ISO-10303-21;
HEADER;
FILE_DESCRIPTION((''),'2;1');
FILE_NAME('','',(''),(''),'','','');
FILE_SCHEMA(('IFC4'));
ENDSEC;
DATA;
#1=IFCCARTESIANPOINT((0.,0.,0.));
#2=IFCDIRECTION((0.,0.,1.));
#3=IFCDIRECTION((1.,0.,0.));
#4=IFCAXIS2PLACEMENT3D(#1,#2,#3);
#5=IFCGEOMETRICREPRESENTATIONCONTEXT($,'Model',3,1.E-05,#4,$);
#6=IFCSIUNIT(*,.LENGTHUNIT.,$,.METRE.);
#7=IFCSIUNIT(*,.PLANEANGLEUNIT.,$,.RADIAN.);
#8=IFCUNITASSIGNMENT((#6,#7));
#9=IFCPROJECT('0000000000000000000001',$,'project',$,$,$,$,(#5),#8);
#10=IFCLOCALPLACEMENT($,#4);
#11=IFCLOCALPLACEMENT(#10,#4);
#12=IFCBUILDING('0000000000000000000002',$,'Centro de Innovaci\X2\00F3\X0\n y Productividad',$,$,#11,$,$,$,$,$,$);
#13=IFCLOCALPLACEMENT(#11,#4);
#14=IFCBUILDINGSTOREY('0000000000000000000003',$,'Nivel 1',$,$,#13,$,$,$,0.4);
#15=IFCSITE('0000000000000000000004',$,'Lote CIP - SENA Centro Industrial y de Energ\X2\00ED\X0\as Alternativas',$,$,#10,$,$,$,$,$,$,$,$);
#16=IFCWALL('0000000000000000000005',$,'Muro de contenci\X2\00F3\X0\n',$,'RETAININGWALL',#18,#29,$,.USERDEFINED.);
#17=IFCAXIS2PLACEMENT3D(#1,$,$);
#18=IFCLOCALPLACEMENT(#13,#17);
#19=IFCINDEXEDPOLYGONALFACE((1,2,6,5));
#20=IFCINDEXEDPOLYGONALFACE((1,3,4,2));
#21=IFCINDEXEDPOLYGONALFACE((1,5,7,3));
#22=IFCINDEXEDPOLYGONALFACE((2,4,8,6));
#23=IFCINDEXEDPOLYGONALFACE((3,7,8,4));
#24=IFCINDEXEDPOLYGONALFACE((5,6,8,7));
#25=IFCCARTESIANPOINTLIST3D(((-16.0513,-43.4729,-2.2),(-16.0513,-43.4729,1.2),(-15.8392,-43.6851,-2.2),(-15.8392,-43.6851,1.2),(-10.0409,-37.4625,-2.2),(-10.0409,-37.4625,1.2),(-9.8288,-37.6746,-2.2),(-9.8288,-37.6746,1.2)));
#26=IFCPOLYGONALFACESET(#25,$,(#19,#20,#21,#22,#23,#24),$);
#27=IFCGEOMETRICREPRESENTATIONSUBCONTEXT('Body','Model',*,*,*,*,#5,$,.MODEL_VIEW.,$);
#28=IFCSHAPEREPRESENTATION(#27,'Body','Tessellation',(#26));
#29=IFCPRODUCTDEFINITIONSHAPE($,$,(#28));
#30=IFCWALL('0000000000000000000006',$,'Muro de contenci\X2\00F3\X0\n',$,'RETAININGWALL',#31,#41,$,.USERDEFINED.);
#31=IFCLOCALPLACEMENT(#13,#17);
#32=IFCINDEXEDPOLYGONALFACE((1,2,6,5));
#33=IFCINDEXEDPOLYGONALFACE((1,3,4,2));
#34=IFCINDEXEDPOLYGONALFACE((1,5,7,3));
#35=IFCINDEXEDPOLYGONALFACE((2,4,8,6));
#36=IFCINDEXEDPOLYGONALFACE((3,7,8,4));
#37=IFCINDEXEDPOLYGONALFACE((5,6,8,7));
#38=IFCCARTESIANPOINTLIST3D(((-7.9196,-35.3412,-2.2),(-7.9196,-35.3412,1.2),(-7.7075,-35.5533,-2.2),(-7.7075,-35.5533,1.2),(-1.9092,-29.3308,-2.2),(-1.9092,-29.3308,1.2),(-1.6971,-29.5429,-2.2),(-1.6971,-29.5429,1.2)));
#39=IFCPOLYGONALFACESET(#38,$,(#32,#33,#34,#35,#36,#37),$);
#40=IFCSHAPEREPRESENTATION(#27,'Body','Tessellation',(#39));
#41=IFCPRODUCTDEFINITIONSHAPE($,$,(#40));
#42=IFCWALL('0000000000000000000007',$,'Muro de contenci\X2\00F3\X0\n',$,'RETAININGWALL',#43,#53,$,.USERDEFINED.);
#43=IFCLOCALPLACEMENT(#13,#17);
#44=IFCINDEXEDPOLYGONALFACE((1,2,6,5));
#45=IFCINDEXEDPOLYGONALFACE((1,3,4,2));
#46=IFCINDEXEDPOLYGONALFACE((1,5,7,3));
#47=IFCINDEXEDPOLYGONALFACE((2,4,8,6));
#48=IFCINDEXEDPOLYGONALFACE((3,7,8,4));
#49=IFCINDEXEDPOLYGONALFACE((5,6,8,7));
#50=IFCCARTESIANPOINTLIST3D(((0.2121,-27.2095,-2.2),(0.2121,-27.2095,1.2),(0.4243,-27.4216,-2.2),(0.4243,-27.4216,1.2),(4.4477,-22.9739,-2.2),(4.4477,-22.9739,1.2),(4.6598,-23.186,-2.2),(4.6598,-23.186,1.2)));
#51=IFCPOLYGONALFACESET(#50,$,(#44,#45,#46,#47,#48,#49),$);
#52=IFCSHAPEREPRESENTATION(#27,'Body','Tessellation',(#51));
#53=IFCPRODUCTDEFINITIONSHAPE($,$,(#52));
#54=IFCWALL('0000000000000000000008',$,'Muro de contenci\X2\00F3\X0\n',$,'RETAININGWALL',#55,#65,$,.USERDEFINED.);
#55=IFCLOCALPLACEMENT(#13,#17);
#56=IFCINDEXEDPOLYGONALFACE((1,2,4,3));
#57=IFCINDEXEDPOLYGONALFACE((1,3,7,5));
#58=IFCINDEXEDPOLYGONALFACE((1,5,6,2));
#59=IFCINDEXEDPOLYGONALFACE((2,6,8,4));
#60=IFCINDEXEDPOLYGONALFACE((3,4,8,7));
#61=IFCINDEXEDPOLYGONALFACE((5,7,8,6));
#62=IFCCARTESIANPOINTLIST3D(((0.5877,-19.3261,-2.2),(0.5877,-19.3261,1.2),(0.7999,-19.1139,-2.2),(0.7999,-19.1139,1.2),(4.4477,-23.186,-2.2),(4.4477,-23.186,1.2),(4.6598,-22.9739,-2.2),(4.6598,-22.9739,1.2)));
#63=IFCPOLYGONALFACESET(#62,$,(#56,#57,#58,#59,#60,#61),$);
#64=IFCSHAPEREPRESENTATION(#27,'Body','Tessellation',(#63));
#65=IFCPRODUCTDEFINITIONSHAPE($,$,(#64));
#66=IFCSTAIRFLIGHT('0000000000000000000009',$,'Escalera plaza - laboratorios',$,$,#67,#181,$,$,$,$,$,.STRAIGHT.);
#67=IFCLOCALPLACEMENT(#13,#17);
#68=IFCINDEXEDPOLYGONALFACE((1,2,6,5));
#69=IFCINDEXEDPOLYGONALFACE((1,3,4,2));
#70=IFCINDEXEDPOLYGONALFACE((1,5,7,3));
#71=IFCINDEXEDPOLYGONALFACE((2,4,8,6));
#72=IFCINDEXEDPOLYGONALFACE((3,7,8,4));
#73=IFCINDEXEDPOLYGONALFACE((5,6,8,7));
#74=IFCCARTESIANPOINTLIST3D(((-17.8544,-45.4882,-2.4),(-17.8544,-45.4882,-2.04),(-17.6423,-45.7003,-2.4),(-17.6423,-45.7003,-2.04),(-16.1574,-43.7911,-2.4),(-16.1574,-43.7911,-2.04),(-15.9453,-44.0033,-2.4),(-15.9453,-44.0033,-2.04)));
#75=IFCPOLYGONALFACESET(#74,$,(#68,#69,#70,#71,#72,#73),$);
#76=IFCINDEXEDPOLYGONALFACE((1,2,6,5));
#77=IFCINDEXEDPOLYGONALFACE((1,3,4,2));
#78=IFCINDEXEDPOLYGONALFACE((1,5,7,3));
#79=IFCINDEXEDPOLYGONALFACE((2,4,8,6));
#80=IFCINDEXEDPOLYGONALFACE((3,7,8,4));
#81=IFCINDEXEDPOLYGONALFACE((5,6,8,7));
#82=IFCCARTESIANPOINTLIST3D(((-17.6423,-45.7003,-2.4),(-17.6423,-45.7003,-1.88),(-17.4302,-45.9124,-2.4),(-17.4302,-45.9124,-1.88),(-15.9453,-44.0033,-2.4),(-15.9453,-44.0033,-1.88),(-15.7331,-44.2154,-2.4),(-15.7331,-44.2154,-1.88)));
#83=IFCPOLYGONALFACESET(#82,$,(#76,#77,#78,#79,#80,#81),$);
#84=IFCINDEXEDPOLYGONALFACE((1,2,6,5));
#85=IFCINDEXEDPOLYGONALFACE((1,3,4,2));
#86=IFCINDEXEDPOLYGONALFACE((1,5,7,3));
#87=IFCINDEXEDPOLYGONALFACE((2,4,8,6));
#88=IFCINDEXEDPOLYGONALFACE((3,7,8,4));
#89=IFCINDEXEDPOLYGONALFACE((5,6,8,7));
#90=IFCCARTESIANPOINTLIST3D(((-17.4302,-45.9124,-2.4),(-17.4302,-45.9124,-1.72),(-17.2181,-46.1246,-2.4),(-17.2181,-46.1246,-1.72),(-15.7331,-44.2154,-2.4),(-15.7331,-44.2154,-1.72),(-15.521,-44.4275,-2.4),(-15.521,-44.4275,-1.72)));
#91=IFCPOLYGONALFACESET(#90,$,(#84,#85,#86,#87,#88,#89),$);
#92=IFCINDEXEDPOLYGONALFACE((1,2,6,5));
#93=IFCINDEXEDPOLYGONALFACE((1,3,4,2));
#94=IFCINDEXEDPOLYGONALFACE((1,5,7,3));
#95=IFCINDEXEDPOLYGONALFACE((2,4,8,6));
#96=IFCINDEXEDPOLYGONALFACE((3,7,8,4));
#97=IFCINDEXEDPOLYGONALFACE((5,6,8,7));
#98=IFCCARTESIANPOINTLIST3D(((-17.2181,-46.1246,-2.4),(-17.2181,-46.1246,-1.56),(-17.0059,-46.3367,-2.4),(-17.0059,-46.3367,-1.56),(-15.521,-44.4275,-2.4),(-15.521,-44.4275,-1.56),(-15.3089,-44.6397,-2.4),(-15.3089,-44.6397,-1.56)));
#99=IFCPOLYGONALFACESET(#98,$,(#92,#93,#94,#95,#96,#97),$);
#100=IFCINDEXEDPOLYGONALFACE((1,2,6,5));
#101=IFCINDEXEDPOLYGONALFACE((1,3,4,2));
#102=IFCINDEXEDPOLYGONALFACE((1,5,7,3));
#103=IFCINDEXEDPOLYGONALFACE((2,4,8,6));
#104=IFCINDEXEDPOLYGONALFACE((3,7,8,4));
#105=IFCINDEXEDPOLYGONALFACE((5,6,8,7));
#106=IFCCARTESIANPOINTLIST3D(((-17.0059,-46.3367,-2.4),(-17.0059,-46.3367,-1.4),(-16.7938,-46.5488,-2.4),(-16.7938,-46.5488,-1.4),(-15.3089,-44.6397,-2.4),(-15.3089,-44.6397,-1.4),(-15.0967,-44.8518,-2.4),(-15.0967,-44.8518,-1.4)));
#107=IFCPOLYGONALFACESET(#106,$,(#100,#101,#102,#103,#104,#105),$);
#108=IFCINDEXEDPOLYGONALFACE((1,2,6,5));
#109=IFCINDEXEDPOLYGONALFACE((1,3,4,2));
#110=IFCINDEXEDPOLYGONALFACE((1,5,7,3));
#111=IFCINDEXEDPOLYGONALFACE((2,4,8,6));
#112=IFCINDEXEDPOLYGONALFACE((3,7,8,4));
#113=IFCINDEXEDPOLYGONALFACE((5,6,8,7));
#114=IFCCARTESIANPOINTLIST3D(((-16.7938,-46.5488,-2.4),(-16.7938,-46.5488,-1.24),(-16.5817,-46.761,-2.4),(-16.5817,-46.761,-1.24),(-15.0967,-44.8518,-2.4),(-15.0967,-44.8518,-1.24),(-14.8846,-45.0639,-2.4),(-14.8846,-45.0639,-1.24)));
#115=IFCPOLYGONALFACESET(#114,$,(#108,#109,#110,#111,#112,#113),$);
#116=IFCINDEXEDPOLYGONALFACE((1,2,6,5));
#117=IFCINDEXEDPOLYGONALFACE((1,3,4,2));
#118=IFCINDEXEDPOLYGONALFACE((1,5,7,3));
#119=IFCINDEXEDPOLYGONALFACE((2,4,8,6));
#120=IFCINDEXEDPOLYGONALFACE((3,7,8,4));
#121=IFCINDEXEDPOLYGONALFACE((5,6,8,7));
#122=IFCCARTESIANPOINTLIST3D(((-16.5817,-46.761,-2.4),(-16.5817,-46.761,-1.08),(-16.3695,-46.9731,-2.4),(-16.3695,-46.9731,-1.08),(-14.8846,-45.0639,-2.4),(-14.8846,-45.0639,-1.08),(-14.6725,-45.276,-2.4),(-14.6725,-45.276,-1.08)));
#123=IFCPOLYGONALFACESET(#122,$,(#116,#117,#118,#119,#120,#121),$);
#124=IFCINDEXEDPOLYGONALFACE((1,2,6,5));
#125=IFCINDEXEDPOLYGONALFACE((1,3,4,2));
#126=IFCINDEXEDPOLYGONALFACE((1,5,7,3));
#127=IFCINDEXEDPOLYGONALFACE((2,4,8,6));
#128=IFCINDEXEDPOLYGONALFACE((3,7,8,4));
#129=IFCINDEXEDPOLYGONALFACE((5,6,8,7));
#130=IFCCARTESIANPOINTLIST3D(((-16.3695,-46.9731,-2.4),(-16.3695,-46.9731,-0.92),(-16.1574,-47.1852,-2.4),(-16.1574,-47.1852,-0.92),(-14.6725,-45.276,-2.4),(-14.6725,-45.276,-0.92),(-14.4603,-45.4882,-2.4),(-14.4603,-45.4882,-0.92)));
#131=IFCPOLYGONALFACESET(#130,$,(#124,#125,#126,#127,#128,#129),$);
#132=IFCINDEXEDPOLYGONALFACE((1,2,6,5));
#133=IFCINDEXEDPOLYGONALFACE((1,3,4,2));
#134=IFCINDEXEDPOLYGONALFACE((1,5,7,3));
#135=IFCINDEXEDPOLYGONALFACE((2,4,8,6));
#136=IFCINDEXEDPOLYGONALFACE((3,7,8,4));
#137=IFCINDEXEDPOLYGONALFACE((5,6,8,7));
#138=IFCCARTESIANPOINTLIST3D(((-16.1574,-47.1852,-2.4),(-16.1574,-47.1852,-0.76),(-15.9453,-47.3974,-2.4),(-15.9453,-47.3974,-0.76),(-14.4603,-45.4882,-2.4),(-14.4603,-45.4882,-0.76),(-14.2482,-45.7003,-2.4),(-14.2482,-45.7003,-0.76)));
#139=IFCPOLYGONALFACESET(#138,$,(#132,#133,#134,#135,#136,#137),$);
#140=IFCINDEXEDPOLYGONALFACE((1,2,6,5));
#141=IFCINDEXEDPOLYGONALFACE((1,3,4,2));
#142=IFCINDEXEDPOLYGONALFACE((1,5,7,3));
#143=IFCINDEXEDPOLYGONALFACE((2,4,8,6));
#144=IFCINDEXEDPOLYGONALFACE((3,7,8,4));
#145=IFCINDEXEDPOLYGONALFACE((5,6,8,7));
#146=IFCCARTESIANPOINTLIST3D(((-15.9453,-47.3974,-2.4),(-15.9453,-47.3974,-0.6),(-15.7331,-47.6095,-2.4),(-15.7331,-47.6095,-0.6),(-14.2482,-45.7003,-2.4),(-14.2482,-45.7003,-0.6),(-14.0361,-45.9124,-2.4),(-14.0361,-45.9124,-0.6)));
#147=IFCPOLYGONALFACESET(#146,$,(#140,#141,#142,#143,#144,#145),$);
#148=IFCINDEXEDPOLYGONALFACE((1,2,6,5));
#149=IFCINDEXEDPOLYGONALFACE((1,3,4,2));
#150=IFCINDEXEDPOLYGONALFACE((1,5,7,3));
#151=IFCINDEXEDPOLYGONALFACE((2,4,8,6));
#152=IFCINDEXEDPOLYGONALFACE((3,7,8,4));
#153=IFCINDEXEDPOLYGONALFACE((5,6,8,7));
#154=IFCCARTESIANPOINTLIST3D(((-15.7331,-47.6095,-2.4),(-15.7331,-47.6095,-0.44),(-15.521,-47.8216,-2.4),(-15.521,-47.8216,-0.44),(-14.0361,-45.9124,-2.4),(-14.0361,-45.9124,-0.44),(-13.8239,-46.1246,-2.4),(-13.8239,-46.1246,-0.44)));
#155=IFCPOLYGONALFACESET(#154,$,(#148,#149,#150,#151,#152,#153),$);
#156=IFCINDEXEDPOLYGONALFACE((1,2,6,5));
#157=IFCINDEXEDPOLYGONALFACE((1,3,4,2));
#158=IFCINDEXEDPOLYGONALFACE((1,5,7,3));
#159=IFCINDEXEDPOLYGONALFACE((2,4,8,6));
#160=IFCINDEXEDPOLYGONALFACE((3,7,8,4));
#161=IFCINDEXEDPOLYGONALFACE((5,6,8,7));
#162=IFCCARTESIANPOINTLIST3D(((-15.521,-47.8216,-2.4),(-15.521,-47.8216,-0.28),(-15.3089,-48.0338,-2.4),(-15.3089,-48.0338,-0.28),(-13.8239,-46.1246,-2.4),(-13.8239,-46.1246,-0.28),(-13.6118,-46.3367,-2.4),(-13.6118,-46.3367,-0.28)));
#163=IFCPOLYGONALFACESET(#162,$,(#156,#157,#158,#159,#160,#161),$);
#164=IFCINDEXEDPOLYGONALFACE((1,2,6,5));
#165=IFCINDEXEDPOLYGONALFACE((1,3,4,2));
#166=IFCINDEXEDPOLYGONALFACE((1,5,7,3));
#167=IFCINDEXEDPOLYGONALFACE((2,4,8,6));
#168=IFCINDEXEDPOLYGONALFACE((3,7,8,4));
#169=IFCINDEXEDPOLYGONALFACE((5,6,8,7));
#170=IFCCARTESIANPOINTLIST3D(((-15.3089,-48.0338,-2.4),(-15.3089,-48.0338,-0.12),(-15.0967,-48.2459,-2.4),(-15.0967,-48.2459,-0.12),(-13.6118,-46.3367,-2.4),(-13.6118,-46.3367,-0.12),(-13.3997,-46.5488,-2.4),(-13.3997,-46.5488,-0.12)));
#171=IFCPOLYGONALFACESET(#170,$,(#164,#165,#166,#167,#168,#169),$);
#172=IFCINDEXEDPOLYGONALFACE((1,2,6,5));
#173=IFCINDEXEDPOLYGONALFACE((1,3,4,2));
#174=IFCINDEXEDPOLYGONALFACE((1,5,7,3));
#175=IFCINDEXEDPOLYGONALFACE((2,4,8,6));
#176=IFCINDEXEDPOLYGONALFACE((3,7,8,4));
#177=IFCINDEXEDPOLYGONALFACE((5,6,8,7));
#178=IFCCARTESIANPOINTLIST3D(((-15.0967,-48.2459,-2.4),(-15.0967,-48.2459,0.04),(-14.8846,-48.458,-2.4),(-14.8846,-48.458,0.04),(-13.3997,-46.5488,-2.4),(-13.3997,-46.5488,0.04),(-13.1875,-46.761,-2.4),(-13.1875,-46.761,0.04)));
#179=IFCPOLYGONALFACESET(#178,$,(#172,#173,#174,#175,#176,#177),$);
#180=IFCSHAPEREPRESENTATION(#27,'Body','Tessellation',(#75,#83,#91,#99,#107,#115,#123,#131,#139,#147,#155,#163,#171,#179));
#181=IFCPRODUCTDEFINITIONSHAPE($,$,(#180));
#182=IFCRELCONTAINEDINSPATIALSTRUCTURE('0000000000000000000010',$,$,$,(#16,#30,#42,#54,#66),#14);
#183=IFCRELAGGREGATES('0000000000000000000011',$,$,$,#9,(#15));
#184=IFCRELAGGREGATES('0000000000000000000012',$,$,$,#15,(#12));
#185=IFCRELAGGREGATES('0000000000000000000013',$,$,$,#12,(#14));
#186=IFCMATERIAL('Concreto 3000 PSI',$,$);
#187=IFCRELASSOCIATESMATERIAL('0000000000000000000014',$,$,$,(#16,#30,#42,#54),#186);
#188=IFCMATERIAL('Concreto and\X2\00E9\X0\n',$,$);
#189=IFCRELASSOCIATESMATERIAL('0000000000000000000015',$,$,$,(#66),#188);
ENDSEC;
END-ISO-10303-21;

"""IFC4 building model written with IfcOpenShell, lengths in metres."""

from ifc_helpers import new_model, si_unit, frame, origin_with_axes, place, context, subcontext, project, spatial, polyline, outline, extrude, material, element, save


model = new_model("IFC4")

# Units and contexts
model_context = context("Model", 3, precision=1e-05, world=origin_with_axes())
body_context = subcontext(model_context, "Body", "Model", "MODEL_VIEW")
ifc_project = project(units=[si_unit("LENGTHUNIT", "METRE"), si_unit("PLANEANGLEUNIT", "RADIAN")], contexts=[model_context])

# Site, building, storey
site_placement = place(None, origin_with_axes())
site = spatial("IfcSite", under=ifc_project, at=site_placement, Name="Lote CIP - SENA Centro Industrial y de Energías Alternativas")
building_placement = place(site_placement, origin_with_axes())
building = spatial("IfcBuilding", under=site, at=building_placement, Name="Centro de Innovación y Productividad")
storey_placement = place(building_placement, origin_with_axes())
storey = spatial("IfcBuildingStorey", under=building, at=storey_placement, Name="Nivel 1", Elevation=0.4)

# Shared definitions
ifc_material_1 = material(Name="Concreto andén")

# Walls
ifc_material_2 = material(Name="Concreto 3000 PSI")
wall_1_placement = place(storey_placement, origin_with_axes())
element("IfcWall", 1, at=wall_1_placement, inside=storey, material=ifc_material_2, Name="Muro de contención", ObjectType="RETAININGWALL", PredefinedType="USERDEFINED", context=body_context, shape_type="SweptSolid", body=[
    extrude(outline(polyline([(-10.0409, -37.4625), (-9.8288, -37.6746), (-15.8392, -43.6851), (-16.0513, -43.4729), (-10.0409, -37.4625)])), frame((0.0, 0.0, -2.2)), (0.0, 0.0, 1.0), 3.4),
])
wall_2_placement = place(storey_placement, origin_with_axes())
element("IfcWall", 2, at=wall_2_placement, inside=storey, material=ifc_material_2, Name="Muro de contención", ObjectType="RETAININGWALL", PredefinedType="USERDEFINED", context=body_context, shape_type="SweptSolid", body=[
    extrude(outline(polyline([(-1.9092, -29.3308), (-1.6971, -29.5429), (-7.7075, -35.5533), (-7.9196, -35.3412), (-1.9092, -29.3308)])), frame((0.0, 0.0, -2.2)), (0.0, 0.0, 1.0), 3.4),
])
wall_3_placement = place(storey_placement, origin_with_axes())
element("IfcWall", 3, at=wall_3_placement, inside=storey, material=ifc_material_2, Name="Muro de contención", ObjectType="RETAININGWALL", PredefinedType="USERDEFINED", context=body_context, shape_type="SweptSolid", body=[
    extrude(outline(polyline([(4.4477, -22.9739), (4.6598, -23.186), (0.4243, -27.4216), (0.2121, -27.2095), (4.4477, -22.9739)])), frame((0.0, 0.0, -2.2)), (0.0, 0.0, 1.0), 3.4),
])
wall_4_placement = place(storey_placement, origin_with_axes())
element("IfcWall", 4, at=wall_4_placement, inside=storey, material=ifc_material_2, Name="Muro de contención", ObjectType="RETAININGWALL", PredefinedType="USERDEFINED", context=body_context, shape_type="SweptSolid", body=[
    extrude(outline(polyline([(0.5877, -19.3261), (0.7999, -19.1139), (4.6598, -22.9739), (4.4477, -23.186), (0.5877, -19.3261)])), frame((0.0, 0.0, -2.2)), (0.0, 0.0, 1.0), 3.4),
])

# Stair flight
stair_flight_1_placement = place(storey_placement, origin_with_axes())
element("IfcStairFlight", 5, at=stair_flight_1_placement, inside=storey, material=ifc_material_1, Name="Escalera plaza - laboratorios", PredefinedType="STRAIGHT", context=body_context, shape_type="SweptSolid", body=[
    extrude(outline(polyline([(-17.8544, -45.4882), (-16.1574, -43.7911), (-15.9453, -44.0033), (-17.6423, -45.7003), (-17.8544, -45.4882)])), frame((0.0, 0.0, -2.4)), (0.0, 0.0, 1.0), 0.36),
    extrude(outline(polyline([(-17.6423, -45.7003), (-15.9453, -44.0033), (-15.7331, -44.2154), (-17.4302, -45.9124), (-17.6423, -45.7003)])), frame((0.0, 0.0, -2.4)), (0.0, 0.0, 1.0), 0.52),
    extrude(outline(polyline([(-17.4302, -45.9124), (-15.7331, -44.2154), (-15.521, -44.4275), (-17.2181, -46.1246), (-17.4302, -45.9124)])), frame((0.0, 0.0, -2.4)), (0.0, 0.0, 1.0), 0.68),
    extrude(outline(polyline([(-17.2181, -46.1246), (-15.521, -44.4275), (-15.3089, -44.6397), (-17.0059, -46.3367), (-17.2181, -46.1246)])), frame((0.0, 0.0, -2.4)), (0.0, 0.0, 1.0), 0.84),
    extrude(outline(polyline([(-17.0059, -46.3367), (-15.3089, -44.6397), (-15.0967, -44.8518), (-16.7938, -46.5488), (-17.0059, -46.3367)])), frame((0.0, 0.0, -2.4)), (0.0, 0.0, 1.0), 1.0),
    extrude(outline(polyline([(-16.7938, -46.5488), (-15.0967, -44.8518), (-14.8846, -45.0639), (-16.5817, -46.761), (-16.7938, -46.5488)])), frame((0.0, 0.0, -2.4)), (0.0, 0.0, 1.0), 1.16),
    extrude(outline(polyline([(-16.5817, -46.761), (-14.8846, -45.0639), (-14.6725, -45.276), (-16.3695, -46.9731), (-16.5817, -46.761)])), frame((0.0, 0.0, -2.4)), (0.0, 0.0, 1.0), 1.32),
    extrude(outline(polyline([(-16.3695, -46.9731), (-14.6725, -45.276), (-14.4603, -45.4882), (-16.1574, -47.1852), (-16.3695, -46.9731)])), frame((0.0, 0.0, -2.4)), (0.0, 0.0, 1.0), 1.48),
    extrude(outline(polyline([(-16.1574, -47.1852), (-14.4603, -45.4882), (-14.2482, -45.7003), (-15.9453, -47.3974), (-16.1574, -47.1852)])), frame((0.0, 0.0, -2.4)), (0.0, 0.0, 1.0), 1.64),
    extrude(outline(polyline([(-15.9453, -47.3974), (-14.2482, -45.7003), (-14.0361, -45.9124), (-15.7331, -47.6095), (-15.9453, -47.3974)])), frame((0.0, 0.0, -2.4)), (0.0, 0.0, 1.0), 1.8),
    extrude(outline(polyline([(-15.7331, -47.6095), (-14.0361, -45.9124), (-13.8239, -46.1246), (-15.521, -47.8216), (-15.7331, -47.6095)])), frame((0.0, 0.0, -2.4)), (0.0, 0.0, 1.0), 1.96),
    extrude(outline(polyline([(-15.521, -47.8216), (-13.8239, -46.1246), (-13.6118, -46.3367), (-15.3089, -48.0338), (-15.521, -47.8216)])), frame((0.0, 0.0, -2.4)), (0.0, 0.0, 1.0), 2.12),
    extrude(outline(polyline([(-15.3089, -48.0338), (-13.6118, -46.3367), (-13.3997, -46.5488), (-15.0967, -48.2459), (-15.3089, -48.0338)])), frame((0.0, 0.0, -2.4)), (0.0, 0.0, 1.0), 2.28),
    extrude(outline(polyline([(-15.0967, -48.2459), (-13.3997, -46.5488), (-13.1875, -46.761), (-14.8846, -48.458), (-15.0967, -48.2459)])), frame((0.0, 0.0, -2.4)), (0.0, 0.0, 1.0), 2.44),
])

save(model, "model.ifc")
